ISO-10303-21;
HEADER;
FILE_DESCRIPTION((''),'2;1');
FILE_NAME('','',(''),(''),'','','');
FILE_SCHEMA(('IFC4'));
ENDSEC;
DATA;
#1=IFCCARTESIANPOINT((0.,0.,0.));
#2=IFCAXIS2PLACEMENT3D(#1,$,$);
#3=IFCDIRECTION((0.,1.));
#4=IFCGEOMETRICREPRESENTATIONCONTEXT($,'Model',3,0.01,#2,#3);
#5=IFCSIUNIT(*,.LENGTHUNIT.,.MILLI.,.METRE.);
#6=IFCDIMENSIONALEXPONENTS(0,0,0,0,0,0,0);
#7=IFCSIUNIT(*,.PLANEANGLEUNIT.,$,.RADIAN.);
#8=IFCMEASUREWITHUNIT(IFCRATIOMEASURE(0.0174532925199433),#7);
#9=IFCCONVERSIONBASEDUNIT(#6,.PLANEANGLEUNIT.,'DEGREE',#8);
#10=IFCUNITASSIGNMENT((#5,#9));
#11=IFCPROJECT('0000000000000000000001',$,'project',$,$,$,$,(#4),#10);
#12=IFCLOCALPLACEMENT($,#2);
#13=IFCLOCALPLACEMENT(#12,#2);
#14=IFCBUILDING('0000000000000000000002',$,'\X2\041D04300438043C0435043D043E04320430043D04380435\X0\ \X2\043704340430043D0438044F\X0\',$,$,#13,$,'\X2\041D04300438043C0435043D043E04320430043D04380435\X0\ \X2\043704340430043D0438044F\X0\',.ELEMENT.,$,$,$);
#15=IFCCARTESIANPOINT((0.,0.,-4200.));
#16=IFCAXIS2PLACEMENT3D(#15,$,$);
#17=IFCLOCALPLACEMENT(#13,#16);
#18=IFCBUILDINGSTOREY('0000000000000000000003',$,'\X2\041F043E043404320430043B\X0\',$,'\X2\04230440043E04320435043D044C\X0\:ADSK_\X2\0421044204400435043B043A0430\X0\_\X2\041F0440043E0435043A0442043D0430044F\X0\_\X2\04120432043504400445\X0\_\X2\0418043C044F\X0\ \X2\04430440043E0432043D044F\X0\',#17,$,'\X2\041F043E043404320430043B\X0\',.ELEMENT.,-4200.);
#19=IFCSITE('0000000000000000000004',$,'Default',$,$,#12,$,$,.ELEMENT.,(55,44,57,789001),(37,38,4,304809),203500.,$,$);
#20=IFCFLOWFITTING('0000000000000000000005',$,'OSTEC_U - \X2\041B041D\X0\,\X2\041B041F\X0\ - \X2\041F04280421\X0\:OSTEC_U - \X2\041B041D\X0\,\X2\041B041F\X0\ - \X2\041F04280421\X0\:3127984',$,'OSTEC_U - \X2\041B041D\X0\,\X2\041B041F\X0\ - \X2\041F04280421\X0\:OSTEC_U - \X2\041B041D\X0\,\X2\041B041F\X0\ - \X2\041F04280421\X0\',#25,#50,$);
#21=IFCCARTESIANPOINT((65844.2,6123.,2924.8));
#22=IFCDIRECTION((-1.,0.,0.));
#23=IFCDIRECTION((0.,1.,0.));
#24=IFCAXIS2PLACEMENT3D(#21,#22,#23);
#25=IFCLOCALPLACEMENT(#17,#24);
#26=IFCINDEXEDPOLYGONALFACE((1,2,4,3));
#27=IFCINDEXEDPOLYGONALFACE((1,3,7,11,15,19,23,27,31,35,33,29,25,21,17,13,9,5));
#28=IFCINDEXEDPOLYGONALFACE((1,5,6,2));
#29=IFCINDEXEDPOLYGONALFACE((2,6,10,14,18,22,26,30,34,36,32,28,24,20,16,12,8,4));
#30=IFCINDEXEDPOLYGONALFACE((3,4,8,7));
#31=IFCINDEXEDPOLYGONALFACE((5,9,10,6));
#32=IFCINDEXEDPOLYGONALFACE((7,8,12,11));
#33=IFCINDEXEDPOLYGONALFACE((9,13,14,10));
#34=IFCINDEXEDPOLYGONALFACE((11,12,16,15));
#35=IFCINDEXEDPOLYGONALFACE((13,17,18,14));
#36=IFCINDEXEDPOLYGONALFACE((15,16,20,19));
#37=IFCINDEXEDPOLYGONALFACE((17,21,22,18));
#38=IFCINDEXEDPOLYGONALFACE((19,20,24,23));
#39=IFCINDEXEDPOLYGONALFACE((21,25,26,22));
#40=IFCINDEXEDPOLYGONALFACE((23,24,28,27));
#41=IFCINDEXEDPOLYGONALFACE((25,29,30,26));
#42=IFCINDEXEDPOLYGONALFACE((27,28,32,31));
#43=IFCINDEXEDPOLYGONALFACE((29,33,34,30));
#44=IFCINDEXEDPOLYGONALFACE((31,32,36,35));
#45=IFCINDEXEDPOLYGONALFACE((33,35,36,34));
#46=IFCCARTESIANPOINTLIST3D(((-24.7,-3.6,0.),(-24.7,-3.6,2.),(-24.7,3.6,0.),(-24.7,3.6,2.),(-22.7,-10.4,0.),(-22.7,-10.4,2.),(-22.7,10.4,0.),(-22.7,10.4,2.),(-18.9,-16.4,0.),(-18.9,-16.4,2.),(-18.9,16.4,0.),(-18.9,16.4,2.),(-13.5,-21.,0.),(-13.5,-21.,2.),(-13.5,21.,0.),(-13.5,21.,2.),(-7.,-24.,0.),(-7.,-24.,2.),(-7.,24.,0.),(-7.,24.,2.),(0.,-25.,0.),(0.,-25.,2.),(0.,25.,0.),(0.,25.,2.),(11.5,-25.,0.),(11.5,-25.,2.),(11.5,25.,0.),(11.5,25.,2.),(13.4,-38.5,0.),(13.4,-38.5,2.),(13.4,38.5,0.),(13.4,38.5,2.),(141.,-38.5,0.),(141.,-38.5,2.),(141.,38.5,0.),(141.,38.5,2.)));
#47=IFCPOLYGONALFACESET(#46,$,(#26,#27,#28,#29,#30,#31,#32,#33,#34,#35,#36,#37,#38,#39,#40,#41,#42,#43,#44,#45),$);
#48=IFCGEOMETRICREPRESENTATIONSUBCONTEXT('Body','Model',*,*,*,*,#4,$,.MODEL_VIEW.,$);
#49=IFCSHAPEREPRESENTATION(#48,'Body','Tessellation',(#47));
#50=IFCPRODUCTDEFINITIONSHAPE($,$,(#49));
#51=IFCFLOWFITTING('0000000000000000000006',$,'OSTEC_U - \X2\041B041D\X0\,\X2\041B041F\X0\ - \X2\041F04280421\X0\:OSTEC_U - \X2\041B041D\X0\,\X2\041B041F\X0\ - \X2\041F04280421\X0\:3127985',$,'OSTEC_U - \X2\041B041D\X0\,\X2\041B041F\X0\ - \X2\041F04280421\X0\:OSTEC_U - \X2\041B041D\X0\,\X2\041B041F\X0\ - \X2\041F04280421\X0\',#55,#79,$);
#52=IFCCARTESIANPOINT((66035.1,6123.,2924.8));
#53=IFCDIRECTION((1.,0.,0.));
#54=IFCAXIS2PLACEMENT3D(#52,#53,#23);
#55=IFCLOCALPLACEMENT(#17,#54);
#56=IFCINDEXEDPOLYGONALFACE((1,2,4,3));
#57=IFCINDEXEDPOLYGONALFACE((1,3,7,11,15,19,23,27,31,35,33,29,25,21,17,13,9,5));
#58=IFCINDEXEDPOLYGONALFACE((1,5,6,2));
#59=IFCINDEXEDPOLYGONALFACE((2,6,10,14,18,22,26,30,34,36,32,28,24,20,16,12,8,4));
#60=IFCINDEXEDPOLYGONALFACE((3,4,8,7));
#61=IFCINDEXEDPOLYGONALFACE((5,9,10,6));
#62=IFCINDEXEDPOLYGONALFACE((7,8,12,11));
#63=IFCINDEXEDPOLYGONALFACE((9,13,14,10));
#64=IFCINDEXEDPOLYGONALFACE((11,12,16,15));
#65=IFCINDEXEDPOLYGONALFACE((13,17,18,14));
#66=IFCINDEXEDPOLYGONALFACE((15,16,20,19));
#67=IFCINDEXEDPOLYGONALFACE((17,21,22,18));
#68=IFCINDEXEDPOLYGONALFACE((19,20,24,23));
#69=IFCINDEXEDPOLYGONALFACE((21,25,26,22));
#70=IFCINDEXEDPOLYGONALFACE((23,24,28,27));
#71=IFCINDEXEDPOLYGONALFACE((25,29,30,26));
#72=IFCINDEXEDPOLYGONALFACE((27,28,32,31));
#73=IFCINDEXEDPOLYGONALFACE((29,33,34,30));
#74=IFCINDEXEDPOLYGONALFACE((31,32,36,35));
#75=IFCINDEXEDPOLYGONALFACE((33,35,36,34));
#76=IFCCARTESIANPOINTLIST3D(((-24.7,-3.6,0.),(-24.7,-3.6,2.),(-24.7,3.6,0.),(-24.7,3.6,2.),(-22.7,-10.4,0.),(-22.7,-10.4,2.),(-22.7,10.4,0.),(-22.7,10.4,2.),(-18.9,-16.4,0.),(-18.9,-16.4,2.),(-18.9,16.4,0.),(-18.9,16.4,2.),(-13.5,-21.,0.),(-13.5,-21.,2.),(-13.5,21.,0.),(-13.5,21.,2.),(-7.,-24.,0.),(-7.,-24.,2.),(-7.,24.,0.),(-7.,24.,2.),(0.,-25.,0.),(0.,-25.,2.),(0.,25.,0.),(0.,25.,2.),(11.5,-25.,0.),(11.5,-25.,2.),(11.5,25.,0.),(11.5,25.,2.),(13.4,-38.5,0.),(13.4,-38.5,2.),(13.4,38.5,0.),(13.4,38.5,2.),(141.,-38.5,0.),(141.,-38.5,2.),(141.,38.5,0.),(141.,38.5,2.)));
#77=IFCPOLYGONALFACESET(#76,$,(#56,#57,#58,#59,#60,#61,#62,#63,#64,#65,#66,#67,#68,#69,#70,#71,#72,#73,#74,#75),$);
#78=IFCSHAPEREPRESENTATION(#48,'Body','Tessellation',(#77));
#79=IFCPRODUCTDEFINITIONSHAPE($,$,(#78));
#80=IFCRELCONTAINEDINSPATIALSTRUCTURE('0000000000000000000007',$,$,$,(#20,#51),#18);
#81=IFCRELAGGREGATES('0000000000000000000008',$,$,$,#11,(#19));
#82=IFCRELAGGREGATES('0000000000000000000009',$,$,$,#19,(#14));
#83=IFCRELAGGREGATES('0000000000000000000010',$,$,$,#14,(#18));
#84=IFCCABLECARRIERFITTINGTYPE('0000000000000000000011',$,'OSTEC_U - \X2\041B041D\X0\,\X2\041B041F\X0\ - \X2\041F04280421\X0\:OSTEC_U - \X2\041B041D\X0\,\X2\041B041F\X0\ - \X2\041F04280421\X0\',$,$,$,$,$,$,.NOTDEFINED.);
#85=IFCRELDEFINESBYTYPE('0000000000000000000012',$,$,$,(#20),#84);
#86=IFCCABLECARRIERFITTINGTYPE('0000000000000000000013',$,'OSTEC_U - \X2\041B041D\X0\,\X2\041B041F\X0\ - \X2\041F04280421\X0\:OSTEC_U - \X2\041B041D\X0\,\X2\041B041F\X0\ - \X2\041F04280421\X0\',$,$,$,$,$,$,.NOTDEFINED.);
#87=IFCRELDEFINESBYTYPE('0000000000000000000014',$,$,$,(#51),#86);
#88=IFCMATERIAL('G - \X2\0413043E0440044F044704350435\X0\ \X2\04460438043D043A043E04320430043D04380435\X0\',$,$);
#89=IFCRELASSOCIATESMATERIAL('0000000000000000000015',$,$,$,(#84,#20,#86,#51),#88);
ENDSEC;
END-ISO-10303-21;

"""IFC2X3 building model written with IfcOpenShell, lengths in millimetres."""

from ifc_helpers import new_model, entity, si_unit, converted_unit, direction, frame, frame_2d, origin, place, context, subcontext, project, spatial, polyline, circle_curve, parameter, trimmed, segment, composite_curve, outline, extrude, source, transform, mapped, material, type_object, type_shapes, element, save


model = new_model("IFC2X3")

# Units and contexts
model_context = context("Model", 3, precision=0.01, world=origin(), true_north=direction((0.0, 1.0)))
body_context = subcontext(model_context, "Body", "Model", "MODEL_VIEW")
ifc_project = project(units=[si_unit("LENGTHUNIT", "METRE", prefix="MILLI"), converted_unit("PLANEANGLEUNIT", "DEGREE", entity("IfcRatioMeasure", 0.0174532925199433), si_unit("PLANEANGLEUNIT", "RADIAN"), dimensions=[0, 0, 0, 0, 0, 0, 0])], contexts=[model_context])

# Site, building, storey
site_placement = place(None, origin())
site = spatial("IfcSite", under=ifc_project, at=site_placement, Name="Default", CompositionType="ELEMENT", RefLatitude=(55, 44, 57, 789001), RefLongitude=(37, 38, 4, 304809), RefElevation=203500.0)
building_placement = place(site_placement, origin())
building = spatial("IfcBuilding", under=site, at=building_placement, Name="Наименование здания", LongName="Наименование здания", CompositionType="ELEMENT")
storey_placement = place(building_placement, frame((0.0, 0.0, -4200.0)))
storey = spatial("IfcBuildingStorey", under=building, at=storey_placement, Name="Подвал", ObjectType="Уровень:ADSK_Стрелка_Проектная_Вверх_Имя уровня", LongName="Подвал", CompositionType="ELEMENT", Elevation=-4200.0)

# Flow fittings
ifc_material = material(Name="G - Горячее цинкование")
shared_shape_1 = source(origin(), body_context, "Body", "SweptSolid", [
    extrude(outline(composite_curve([segment(trimmed(circle_curve(frame_2d((-41.5, 0.0), x_axis=(1.0, 0.0)), 25.0), [parameter(90.0)], [parameter(270.0)], True, "PARAMETER"), True, "CONTINUOUS"), segment(polyline([(-41.5, -25.0), (-30.0, -25.0)]), True, "CONTINUOUS"), segment(polyline([(-30.0, -25.0), (-28.1, -38.5)]), True, "CONTINUOUS"), segment(polyline([(-28.1, -38.5), (99.5, -38.5)]), True, "CONTINUOUS"), segment(polyline([(99.5, -38.5), (99.5, 38.5)]), True, "CONTINUOUS"), segment(polyline([(99.5, 38.5), (-28.1, 38.5)]), True, "CONTINUOUS"), segment(polyline([(-28.1, 38.5), (-30.0, 25.0)]), True, "CONTINUOUS"), segment(polyline([(-30.0, 25.0), (-41.5, 25.0)]), True, "CONTINUOUS")], self_intersect=False)), frame((41.5, 0.0, 0.0), z_axis=(0.0, 0.0, -1.0), x_axis=(1.0, 0.0, 0.0)), (0.0, 0.0, -1.0), 2.0),
])
cable_carrier_fitting_type_1 = type_object("IfcCableCarrierFittingType", Name="OSTEC_U - ЛН,ЛП - ПШС:OSTEC_U - ЛН,ЛП - ПШС", PredefinedType="NOTDEFINED", material=ifc_material)
type_shapes(cable_carrier_fitting_type_1, [shared_shape_1])
flow_fitting_1_placement = place(storey_placement, frame((65844.2, 6123.0, 2924.8), z_axis=(-1.0, 0.0, 0.0), x_axis=(0.0, 1.0, 0.0)))
element("IfcFlowFitting", 1, at=flow_fitting_1_placement, inside=storey, type_object=cable_carrier_fitting_type_1, material=ifc_material, Name="OSTEC_U - ЛН,ЛП - ПШС:OSTEC_U - ЛН,ЛП - ПШС:3127984", ObjectType="OSTEC_U - ЛН,ЛП - ПШС:OSTEC_U - ЛН,ЛП - ПШС", context=body_context, shape_type="MappedRepresentation", body=[
    mapped(shared_shape_1, transform((0.0, 0.0, 0.0), scale=1.0)),
])
shared_shape_2 = source(origin(), body_context, "Body", "SweptSolid", [
    extrude(outline(composite_curve([segment(trimmed(circle_curve(frame_2d((-41.5, 0.0), x_axis=(1.0, 0.0)), 25.0), [parameter(90.0)], [parameter(270.0)], True, "PARAMETER"), True, "CONTINUOUS"), segment(polyline([(-41.5, -25.0), (-30.0, -25.0)]), True, "CONTINUOUS"), segment(polyline([(-30.0, -25.0), (-28.1, -38.5)]), True, "CONTINUOUS"), segment(polyline([(-28.1, -38.5), (99.5, -38.5)]), True, "CONTINUOUS"), segment(polyline([(99.5, -38.5), (99.5, 38.5)]), True, "CONTINUOUS"), segment(polyline([(99.5, 38.5), (-28.1, 38.5)]), True, "CONTINUOUS"), segment(polyline([(-28.1, 38.5), (-30.0, 25.0)]), True, "CONTINUOUS"), segment(polyline([(-30.0, 25.0), (-41.5, 25.0)]), True, "CONTINUOUS")], self_intersect=False)), frame((41.5, 0.0, 0.0)), (0.0, 0.0, 1.0), 2.0),
])
cable_carrier_fitting_type_2 = type_object("IfcCableCarrierFittingType", Name="OSTEC_U - ЛН,ЛП - ПШС:OSTEC_U - ЛН,ЛП - ПШС", PredefinedType="NOTDEFINED", material=ifc_material)
type_shapes(cable_carrier_fitting_type_2, [shared_shape_2])
flow_fitting_2_placement = place(storey_placement, frame((66035.1, 6123.0, 2924.8), z_axis=(1.0, 0.0, 0.0), x_axis=(0.0, 1.0, 0.0)))
element("IfcFlowFitting", 2, at=flow_fitting_2_placement, inside=storey, type_object=cable_carrier_fitting_type_2, material=ifc_material, Name="OSTEC_U - ЛН,ЛП - ПШС:OSTEC_U - ЛН,ЛП - ПШС:3127985", ObjectType="OSTEC_U - ЛН,ЛП - ПШС:OSTEC_U - ЛН,ЛП - ПШС", context=body_context, shape_type="MappedRepresentation", body=[
    mapped(shared_shape_2, transform((0.0, 0.0, 0.0), scale=1.0)),
])

save(model, "model.ifc")
